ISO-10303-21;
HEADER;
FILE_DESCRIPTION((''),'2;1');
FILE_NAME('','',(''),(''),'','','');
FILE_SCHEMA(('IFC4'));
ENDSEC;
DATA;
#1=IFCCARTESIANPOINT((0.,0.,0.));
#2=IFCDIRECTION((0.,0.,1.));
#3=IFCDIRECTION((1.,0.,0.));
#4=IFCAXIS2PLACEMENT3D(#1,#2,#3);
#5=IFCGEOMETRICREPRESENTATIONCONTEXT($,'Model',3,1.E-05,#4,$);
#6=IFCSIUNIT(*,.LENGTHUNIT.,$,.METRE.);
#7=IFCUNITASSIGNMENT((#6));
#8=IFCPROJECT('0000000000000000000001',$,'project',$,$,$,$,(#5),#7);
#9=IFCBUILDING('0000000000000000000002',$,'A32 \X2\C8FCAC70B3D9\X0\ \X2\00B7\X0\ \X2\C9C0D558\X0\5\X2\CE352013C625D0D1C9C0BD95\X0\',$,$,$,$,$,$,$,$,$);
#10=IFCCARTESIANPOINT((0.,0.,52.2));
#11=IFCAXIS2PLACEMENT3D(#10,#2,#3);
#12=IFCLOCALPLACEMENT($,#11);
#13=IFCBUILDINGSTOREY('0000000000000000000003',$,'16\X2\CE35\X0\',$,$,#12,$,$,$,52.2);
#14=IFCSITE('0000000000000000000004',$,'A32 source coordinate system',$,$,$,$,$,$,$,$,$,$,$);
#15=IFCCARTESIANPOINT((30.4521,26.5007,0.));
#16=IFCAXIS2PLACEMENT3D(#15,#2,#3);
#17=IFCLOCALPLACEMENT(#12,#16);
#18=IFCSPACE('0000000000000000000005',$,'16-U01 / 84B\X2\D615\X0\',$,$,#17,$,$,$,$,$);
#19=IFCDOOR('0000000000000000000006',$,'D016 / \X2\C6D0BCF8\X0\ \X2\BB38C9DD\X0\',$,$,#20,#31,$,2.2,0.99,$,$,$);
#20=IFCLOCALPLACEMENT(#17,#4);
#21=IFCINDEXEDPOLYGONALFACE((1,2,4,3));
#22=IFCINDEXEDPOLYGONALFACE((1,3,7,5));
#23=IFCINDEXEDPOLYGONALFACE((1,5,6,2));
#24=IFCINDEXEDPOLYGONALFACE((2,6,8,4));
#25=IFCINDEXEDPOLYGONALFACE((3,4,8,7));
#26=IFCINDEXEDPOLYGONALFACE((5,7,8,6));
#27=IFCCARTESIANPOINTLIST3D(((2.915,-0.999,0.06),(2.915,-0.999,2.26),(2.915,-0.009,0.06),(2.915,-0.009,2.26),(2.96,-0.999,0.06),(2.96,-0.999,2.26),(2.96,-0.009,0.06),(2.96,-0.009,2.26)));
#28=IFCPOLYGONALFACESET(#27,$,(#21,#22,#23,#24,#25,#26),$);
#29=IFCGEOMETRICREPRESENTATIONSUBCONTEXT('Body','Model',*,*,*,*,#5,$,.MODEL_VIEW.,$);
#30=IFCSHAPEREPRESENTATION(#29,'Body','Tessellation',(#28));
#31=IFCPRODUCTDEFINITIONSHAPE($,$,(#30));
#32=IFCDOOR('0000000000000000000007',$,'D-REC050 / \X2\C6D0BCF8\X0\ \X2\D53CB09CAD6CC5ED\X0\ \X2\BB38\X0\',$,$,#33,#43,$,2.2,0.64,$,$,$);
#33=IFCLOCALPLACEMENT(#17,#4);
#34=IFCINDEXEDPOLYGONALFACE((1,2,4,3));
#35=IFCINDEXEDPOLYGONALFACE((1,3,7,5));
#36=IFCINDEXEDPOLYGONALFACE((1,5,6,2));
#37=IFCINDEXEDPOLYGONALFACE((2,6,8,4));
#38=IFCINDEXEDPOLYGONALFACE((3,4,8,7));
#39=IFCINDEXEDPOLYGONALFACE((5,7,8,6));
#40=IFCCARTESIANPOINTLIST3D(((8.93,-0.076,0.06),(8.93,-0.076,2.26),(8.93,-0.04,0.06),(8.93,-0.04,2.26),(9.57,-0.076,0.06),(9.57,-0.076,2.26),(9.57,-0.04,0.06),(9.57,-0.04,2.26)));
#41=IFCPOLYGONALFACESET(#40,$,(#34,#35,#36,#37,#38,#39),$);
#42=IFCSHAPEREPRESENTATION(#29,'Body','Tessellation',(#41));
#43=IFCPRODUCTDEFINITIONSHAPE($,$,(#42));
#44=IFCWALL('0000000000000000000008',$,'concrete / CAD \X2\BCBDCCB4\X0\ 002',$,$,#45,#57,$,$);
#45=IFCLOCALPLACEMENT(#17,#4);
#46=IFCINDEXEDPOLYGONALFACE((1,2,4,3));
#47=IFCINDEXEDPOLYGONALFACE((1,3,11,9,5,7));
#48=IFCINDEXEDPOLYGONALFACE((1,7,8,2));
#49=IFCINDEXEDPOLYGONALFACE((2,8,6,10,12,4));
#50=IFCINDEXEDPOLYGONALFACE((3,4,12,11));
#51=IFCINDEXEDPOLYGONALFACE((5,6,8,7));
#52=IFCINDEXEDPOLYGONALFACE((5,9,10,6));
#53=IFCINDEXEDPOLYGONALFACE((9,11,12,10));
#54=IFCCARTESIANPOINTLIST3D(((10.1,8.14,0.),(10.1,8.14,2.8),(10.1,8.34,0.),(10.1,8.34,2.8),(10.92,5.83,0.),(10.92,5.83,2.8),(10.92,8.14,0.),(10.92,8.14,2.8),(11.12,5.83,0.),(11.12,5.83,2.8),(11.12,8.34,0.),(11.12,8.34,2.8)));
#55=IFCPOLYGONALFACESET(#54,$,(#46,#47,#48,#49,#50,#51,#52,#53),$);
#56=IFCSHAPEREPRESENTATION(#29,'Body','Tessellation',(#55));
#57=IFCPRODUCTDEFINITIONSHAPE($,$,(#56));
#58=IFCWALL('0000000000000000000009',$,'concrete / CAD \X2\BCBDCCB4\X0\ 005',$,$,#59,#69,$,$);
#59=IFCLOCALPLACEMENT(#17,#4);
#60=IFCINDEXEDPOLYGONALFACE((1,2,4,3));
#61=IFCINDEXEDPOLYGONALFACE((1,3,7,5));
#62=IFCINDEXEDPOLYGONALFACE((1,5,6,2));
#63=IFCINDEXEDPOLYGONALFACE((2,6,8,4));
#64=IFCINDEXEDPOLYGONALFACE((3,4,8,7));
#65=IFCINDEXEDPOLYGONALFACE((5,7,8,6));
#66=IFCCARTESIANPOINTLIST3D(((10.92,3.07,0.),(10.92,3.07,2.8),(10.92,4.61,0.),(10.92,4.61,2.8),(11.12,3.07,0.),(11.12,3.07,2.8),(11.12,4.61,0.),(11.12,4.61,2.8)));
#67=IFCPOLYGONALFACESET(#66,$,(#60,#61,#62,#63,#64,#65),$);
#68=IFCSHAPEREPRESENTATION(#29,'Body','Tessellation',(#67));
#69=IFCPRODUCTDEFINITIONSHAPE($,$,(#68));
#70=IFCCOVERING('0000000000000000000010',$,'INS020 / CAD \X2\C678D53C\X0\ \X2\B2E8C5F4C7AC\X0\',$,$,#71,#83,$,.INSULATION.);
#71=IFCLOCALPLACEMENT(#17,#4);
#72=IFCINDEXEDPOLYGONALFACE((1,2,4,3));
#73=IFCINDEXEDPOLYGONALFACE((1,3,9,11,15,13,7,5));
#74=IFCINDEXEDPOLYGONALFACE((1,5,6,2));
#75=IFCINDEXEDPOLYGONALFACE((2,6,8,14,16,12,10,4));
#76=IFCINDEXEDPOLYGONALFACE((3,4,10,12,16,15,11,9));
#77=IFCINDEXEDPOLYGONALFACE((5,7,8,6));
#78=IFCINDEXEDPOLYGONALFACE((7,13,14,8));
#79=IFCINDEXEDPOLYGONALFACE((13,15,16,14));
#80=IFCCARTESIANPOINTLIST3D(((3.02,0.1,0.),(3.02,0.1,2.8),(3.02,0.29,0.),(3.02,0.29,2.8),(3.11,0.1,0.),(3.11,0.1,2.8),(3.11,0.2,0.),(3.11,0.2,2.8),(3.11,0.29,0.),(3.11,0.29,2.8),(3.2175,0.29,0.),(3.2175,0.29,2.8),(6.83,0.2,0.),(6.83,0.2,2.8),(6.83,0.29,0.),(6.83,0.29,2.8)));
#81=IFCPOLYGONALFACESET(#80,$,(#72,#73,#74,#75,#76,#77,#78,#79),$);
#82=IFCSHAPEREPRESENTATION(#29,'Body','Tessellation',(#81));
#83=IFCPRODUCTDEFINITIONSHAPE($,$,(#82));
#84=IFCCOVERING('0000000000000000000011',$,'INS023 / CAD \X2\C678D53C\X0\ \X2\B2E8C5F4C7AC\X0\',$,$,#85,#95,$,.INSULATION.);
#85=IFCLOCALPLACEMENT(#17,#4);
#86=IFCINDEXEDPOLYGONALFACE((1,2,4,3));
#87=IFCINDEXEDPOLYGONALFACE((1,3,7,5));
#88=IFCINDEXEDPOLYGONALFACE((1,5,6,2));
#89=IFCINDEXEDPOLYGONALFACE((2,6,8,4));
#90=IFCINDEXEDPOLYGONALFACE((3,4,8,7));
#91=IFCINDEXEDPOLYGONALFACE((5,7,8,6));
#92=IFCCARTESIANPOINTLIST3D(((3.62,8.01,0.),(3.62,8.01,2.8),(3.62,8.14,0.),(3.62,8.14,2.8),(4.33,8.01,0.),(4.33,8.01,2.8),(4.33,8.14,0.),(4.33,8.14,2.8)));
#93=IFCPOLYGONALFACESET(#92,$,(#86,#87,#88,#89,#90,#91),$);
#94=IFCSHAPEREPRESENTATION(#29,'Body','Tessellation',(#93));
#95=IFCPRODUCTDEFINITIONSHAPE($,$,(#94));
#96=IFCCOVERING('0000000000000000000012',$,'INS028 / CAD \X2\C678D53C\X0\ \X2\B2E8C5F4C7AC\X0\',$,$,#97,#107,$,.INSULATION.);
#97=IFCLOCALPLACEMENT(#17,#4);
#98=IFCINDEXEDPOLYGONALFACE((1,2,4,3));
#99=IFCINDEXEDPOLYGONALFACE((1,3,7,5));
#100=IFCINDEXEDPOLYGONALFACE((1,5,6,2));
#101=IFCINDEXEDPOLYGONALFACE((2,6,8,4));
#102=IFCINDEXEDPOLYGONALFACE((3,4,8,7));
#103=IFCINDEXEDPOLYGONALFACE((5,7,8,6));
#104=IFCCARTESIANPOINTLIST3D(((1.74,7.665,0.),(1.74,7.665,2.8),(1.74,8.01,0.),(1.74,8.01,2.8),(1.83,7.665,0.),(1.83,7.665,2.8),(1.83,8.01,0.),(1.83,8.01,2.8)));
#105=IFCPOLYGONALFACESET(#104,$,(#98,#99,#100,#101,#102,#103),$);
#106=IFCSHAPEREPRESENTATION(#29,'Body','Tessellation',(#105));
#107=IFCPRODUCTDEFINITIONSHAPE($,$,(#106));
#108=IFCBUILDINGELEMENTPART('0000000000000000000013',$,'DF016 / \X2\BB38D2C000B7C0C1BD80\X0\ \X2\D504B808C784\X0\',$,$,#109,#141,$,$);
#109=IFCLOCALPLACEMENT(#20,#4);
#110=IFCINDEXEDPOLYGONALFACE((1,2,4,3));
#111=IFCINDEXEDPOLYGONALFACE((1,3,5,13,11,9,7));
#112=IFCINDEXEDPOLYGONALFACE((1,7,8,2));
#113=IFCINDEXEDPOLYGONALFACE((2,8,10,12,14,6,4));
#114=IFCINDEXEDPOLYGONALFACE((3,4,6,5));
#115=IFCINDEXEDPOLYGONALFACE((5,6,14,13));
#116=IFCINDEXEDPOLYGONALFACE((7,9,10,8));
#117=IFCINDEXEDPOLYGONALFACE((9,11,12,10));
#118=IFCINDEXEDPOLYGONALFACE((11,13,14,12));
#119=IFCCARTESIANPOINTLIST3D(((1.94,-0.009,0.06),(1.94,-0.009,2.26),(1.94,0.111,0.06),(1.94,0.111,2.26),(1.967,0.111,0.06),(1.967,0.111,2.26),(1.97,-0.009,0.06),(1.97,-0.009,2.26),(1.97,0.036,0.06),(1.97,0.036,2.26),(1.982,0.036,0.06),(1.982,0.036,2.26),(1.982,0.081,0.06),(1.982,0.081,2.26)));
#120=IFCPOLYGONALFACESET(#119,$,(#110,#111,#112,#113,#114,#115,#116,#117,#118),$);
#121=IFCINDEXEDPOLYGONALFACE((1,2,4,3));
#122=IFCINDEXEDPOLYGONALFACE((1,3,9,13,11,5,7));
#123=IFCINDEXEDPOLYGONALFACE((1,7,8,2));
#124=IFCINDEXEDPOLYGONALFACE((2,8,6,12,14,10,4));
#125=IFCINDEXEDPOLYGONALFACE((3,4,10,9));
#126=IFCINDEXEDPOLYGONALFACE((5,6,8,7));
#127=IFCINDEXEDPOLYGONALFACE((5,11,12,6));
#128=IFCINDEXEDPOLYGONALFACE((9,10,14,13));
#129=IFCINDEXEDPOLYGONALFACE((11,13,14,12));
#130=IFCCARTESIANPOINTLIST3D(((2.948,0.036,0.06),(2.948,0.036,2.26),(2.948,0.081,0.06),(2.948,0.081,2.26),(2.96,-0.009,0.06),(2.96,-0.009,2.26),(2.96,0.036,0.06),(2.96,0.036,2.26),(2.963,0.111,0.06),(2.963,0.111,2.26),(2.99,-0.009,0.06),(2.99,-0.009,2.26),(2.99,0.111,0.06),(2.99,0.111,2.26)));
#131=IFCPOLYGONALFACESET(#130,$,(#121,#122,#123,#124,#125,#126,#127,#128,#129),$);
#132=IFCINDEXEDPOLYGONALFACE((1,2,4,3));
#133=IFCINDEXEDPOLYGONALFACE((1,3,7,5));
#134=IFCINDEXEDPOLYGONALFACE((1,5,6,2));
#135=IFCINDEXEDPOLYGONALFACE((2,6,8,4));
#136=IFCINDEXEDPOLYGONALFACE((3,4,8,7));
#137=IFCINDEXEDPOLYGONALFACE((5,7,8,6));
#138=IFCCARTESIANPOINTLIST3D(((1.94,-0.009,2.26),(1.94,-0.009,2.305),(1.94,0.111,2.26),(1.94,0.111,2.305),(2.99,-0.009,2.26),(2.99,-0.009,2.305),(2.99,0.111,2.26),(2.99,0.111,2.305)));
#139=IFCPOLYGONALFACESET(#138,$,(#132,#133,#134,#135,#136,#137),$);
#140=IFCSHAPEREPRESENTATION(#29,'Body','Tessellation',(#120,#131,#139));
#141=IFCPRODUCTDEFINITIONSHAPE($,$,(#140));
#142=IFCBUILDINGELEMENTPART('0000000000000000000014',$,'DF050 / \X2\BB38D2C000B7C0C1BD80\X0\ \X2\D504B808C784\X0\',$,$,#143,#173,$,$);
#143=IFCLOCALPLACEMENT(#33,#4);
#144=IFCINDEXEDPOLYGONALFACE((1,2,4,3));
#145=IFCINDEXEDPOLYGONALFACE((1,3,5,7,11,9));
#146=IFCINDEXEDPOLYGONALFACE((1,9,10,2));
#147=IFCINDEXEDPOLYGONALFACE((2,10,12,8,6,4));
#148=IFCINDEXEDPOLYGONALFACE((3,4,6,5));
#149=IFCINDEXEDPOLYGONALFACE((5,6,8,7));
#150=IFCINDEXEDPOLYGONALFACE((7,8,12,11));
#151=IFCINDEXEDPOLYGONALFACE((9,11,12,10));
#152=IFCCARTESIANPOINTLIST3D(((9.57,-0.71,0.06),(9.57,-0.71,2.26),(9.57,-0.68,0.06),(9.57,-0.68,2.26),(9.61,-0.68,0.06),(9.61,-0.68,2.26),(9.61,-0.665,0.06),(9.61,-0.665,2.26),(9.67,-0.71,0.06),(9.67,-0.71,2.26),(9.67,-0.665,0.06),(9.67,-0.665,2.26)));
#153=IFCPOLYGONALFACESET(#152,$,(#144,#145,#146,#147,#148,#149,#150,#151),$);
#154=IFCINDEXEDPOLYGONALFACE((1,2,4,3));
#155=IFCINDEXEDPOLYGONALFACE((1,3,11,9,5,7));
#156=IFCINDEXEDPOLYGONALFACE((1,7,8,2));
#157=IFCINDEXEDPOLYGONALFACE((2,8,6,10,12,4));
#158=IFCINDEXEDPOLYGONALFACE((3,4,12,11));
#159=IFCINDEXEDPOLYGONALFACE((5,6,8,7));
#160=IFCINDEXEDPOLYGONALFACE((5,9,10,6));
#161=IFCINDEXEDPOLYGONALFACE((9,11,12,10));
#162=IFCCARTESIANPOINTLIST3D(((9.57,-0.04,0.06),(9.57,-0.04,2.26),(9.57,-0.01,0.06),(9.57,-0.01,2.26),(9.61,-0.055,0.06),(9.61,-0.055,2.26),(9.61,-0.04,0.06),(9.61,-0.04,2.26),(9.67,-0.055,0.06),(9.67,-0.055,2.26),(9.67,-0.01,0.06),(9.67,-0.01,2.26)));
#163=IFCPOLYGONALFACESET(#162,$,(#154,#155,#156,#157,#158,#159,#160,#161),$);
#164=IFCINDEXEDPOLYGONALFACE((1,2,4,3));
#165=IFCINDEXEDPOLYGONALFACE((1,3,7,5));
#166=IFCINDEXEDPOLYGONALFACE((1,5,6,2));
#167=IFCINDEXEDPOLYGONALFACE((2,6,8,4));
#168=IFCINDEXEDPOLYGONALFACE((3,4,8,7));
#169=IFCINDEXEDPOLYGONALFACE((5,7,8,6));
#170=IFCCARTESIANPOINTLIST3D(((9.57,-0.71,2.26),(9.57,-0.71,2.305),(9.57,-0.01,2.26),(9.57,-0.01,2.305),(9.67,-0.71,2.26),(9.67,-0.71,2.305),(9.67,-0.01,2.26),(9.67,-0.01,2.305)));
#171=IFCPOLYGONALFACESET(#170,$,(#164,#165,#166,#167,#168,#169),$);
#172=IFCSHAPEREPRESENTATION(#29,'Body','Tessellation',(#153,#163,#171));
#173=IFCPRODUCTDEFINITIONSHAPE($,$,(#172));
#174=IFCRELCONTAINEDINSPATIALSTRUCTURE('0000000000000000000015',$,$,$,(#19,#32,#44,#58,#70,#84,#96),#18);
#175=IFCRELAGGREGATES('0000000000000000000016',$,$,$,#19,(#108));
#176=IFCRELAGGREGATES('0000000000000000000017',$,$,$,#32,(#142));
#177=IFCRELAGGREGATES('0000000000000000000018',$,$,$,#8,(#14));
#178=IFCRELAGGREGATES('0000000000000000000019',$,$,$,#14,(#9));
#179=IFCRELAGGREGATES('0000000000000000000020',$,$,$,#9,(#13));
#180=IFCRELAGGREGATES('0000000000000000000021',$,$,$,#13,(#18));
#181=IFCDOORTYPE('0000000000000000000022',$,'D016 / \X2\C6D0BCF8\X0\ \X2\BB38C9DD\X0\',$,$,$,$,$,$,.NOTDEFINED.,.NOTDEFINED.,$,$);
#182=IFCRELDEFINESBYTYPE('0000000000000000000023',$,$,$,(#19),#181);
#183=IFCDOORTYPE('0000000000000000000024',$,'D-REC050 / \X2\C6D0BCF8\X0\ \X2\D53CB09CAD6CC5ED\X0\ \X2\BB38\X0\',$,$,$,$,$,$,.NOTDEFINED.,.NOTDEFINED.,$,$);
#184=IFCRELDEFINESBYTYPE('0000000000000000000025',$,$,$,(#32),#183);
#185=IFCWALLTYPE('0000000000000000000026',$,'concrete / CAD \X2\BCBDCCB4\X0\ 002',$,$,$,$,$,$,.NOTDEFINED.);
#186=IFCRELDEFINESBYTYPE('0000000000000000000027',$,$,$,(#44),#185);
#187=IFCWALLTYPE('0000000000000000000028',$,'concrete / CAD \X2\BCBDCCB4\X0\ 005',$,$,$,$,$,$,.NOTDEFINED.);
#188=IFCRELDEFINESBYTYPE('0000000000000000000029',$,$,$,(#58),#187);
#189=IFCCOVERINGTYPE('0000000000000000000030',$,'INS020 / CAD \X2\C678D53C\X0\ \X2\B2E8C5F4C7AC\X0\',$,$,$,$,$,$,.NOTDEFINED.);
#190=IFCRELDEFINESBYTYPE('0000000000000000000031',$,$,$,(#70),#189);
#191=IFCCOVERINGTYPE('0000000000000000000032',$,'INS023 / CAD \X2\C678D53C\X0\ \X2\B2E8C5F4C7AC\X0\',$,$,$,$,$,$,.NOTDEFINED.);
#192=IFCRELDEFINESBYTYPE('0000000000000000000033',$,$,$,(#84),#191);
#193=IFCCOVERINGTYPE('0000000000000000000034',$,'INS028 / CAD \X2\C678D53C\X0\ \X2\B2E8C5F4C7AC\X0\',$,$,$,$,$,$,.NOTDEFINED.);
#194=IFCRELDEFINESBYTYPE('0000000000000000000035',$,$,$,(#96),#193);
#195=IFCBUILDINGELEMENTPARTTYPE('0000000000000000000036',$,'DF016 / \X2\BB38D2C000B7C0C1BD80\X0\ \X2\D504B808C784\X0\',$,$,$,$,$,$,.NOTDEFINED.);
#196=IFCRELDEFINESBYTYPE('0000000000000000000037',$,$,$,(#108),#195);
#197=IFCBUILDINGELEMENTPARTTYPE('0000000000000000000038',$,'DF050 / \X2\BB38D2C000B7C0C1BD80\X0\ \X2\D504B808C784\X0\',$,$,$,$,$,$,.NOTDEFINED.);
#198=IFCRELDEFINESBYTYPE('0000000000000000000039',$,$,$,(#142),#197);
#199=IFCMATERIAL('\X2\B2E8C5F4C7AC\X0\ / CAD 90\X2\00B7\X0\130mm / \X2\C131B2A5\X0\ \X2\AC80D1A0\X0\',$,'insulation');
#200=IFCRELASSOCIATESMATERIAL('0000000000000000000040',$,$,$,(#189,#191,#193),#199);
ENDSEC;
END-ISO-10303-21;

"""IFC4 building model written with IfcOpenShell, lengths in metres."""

from ifc_helpers import new_model, si_unit, frame, origin, origin_with_axes, place, context, subcontext, project, spatial, polyline, outline, extrude, source, transform, mapped, material, type_object, type_shapes, element, aggregate, save


model = new_model("IFC4")

# Units and contexts
model_context = context("Model", 3, precision=1e-05, world=origin_with_axes())
body_context = subcontext(model_context, "Body", "Model", "MODEL_VIEW")
ifc_project = project(units=[si_unit("LENGTHUNIT", "METRE")], contexts=[model_context])

# Site, building, storey, space
storey_placement = place(None, frame((0.0, 0.0, 52.2), z_axis=(0.0, 0.0, 1.0), x_axis=(1.0, 0.0, 0.0)))
space_placement = place(storey_placement, frame((30.4521, 26.5007, 0.0), z_axis=(0.0, 0.0, 1.0), x_axis=(1.0, 0.0, 0.0)))
site = spatial("IfcSite", under=ifc_project, Name="A32 source coordinate system")
building = spatial("IfcBuilding", under=site, Name="A32 주거동 · 지하5층–옥탑지붕")
storey = spatial("IfcBuildingStorey", under=building, at=storey_placement, Name="16층", Elevation=52.2)
space = spatial("IfcSpace", under=storey, at=space_placement, Name="16-U01 / 84B형")

# Doors
door_type_1 = type_object("IfcDoorType", Name="D016 / 원본 문짝", OperationType="NOTDEFINED", PredefinedType="NOTDEFINED")
shared_shape_1 = source(origin(), body_context, "Body", "SweptSolid", [
    extrude(outline(polyline([(2.96, -0.009), (2.96, -0.999), (2.915, -0.999), (2.915, -0.009), (2.96, -0.009)])), frame((0.0, 0.0, 0.06)), (0.0, 0.0, 1.0), 2.2),
])
type_shapes(door_type_1, [shared_shape_1])
door_1_placement = place(space_placement, origin_with_axes())
door_1 = element("IfcDoor", 1, at=door_1_placement, inside=space, type_object=door_type_1, Name="D016 / 원본 문짝", OverallHeight=2.2, OverallWidth=0.99, context=body_context, shape_type="MappedRepresentation", body=[
    mapped(shared_shape_1, transform((0.0, 0.0, 0.0), scale=1.0)),
])
door_type_2 = type_object("IfcDoorType", Name="D-REC050 / 원본 피난구역 문", OperationType="NOTDEFINED", PredefinedType="NOTDEFINED")
shared_shape_2 = source(origin(), body_context, "Body", "SweptSolid", [
    extrude(outline(polyline([(9.57, -0.04), (9.57, -0.076), (8.93, -0.076), (8.93, -0.04), (9.57, -0.04)])), frame((0.0, 0.0, 0.06)), (0.0, 0.0, 1.0), 2.2),
])
type_shapes(door_type_2, [shared_shape_2])
door_2_placement = place(space_placement, origin_with_axes())
door_2 = element("IfcDoor", 2, at=door_2_placement, inside=space, type_object=door_type_2, Name="D-REC050 / 원본 피난구역 문", OverallHeight=2.2, OverallWidth=0.64, context=body_context, shape_type="MappedRepresentation", body=[
    mapped(shared_shape_2, transform((0.0, 0.0, 0.0), scale=1.0)),
])

# Walls
wall_type_1 = type_object("IfcWallType", Name="concrete / CAD 벽체 002", PredefinedType="NOTDEFINED")
shared_shape_3 = source(origin(), body_context, "Body", "SweptSolid", [
    extrude(outline(polyline([(11.12, 5.83), (10.92, 5.83), (10.92, 8.14), (10.1, 8.14), (10.1, 8.34), (11.12, 8.34), (11.12, 5.83)])), origin(), (0.0, 0.0, 1.0), 2.8),
])
type_shapes(wall_type_1, [shared_shape_3])
wall_1_placement = place(space_placement, origin_with_axes())
element("IfcWall", 3, at=wall_1_placement, inside=space, type_object=wall_type_1, Name="concrete / CAD 벽체 002", context=body_context, shape_type="MappedRepresentation", body=[
    mapped(shared_shape_3, transform((0.0, 0.0, 0.0), scale=1.0)),
])
wall_type_2 = type_object("IfcWallType", Name="concrete / CAD 벽체 005", PredefinedType="NOTDEFINED")
shared_shape_4 = source(origin(), body_context, "Body", "SweptSolid", [
    extrude(outline(polyline([(11.12, 3.07), (10.92, 3.07), (10.92, 4.61), (11.12, 4.61), (11.12, 3.07)])), origin(), (0.0, 0.0, 1.0), 2.8),
])
type_shapes(wall_type_2, [shared_shape_4])
wall_2_placement = place(space_placement, origin_with_axes())
element("IfcWall", 4, at=wall_2_placement, inside=space, type_object=wall_type_2, Name="concrete / CAD 벽체 005", context=body_context, shape_type="MappedRepresentation", body=[
    mapped(shared_shape_4, transform((0.0, 0.0, 0.0), scale=1.0)),
])

# Coverings
ifc_material = material(Name="단열재 / CAD 90·130mm / 성능 검토", Category="insulation")
covering_type_1 = type_object("IfcCoveringType", Name="INS020 / CAD 외피 단열재", PredefinedType="NOTDEFINED", material=ifc_material)
shared_shape_5 = source(origin(), body_context, "Body", "SweptSolid", [
    extrude(outline(polyline([(3.11, 0.2), (3.11, 0.1), (3.02, 0.1), (3.02, 0.29), (3.11, 0.29), (3.2175, 0.29), (6.83, 0.29), (6.83, 0.2), (3.11, 0.2)])), origin(), (0.0, 0.0, 1.0), 2.8),
])
type_shapes(covering_type_1, [shared_shape_5])
covering_1_placement = place(space_placement, origin_with_axes())
element("IfcCovering", 5, at=covering_1_placement, inside=space, type_object=covering_type_1, Name="INS020 / CAD 외피 단열재", PredefinedType="INSULATION", context=body_context, shape_type="MappedRepresentation", body=[
    mapped(shared_shape_5, transform((0.0, 0.0, 0.0), scale=1.0)),
])
covering_type_2 = type_object("IfcCoveringType", Name="INS023 / CAD 외피 단열재", PredefinedType="NOTDEFINED", material=ifc_material)
shared_shape_6 = source(origin(), body_context, "Body", "SweptSolid", [
    extrude(outline(polyline([(4.33, 8.01), (3.62, 8.01), (3.62, 8.14), (4.33, 8.14), (4.33, 8.01)])), origin(), (0.0, 0.0, 1.0), 2.8),
])
type_shapes(covering_type_2, [shared_shape_6])
covering_2_placement = place(space_placement, origin_with_axes())
element("IfcCovering", 6, at=covering_2_placement, inside=space, type_object=covering_type_2, Name="INS023 / CAD 외피 단열재", PredefinedType="INSULATION", context=body_context, shape_type="MappedRepresentation", body=[
    mapped(shared_shape_6, transform((0.0, 0.0, 0.0), scale=1.0)),
])
covering_type_3 = type_object("IfcCoveringType", Name="INS028 / CAD 외피 단열재", PredefinedType="NOTDEFINED", material=ifc_material)
shared_shape_7 = source(origin(), body_context, "Body", "SweptSolid", [
    extrude(outline(polyline([(1.74, 8.01), (1.83, 8.01), (1.83, 7.665), (1.74, 7.665), (1.74, 8.01)])), origin(), (0.0, 0.0, 1.0), 2.8),
])
type_shapes(covering_type_3, [shared_shape_7])
covering_3_placement = place(space_placement, origin_with_axes())
element("IfcCovering", 7, at=covering_3_placement, inside=space, type_object=covering_type_3, Name="INS028 / CAD 외피 단열재", PredefinedType="INSULATION", context=body_context, shape_type="MappedRepresentation", body=[
    mapped(shared_shape_7, transform((0.0, 0.0, 0.0), scale=1.0)),
])

# Building element parts
building_element_part_type_1 = type_object("IfcBuildingElementPartType", Name="DF016 / 문틀·상부 프레임", PredefinedType="NOTDEFINED")
shared_shape_8 = source(origin(), body_context, "Body", "SweptSolid", [
    extrude(outline(polyline([(1.94, 0.111), (1.967, 0.111), (1.982, 0.081), (1.982, 0.036), (1.97, 0.036), (1.97, -0.009), (1.94, -0.009), (1.94, 0.111)])), frame((0.0, 0.0, 0.06)), (0.0, 0.0, 1.0), 2.2),
    extrude(outline(polyline([(2.96, -0.009), (2.96, 0.036), (2.948, 0.036), (2.948, 0.081), (2.963, 0.111), (2.99, 0.111), (2.99, -0.009), (2.96, -0.009)])), frame((0.0, 0.0, 0.06)), (0.0, 0.0, 1.0), 2.2),
    extrude(outline(polyline([(1.94, -0.009), (1.94, 0.111), (2.99, 0.111), (2.99, -0.009), (1.94, -0.009)])), frame((0.0, 0.0, 2.26)), (0.0, 0.0, 1.0), 0.045),
])
type_shapes(building_element_part_type_1, [shared_shape_8])
building_element_part_1_placement = place(door_1_placement, origin_with_axes())
building_element_part_1 = element("IfcBuildingElementPart", 8, at=building_element_part_1_placement, type_object=building_element_part_type_1, Name="DF016 / 문틀·상부 프레임", context=body_context, shape_type="MappedRepresentation", body=[
    mapped(shared_shape_8, transform((0.0, 0.0, 0.0), scale=1.0)),
])
aggregate(door_1, [building_element_part_1])
building_element_part_type_2 = type_object("IfcBuildingElementPartType", Name="DF050 / 문틀·상부 프레임", PredefinedType="NOTDEFINED")
shared_shape_9 = source(origin(), body_context, "Body", "SweptSolid", [
    extrude(outline(polyline([(9.57, -0.68), (9.61, -0.68), (9.61, -0.665), (9.67, -0.665), (9.67, -0.71), (9.57, -0.71), (9.57, -0.68)])), frame((0.0, 0.0, 0.06)), (0.0, 0.0, 1.0), 2.2),
    extrude(outline(polyline([(9.67, -0.01), (9.67, -0.055), (9.61, -0.055), (9.61, -0.04), (9.57, -0.04), (9.57, -0.01), (9.67, -0.01)])), frame((0.0, 0.0, 0.06)), (0.0, 0.0, 1.0), 2.2),
    extrude(outline(polyline([(9.57, -0.71), (9.57, -0.01), (9.67, -0.01), (9.67, -0.71), (9.57, -0.71)])), frame((0.0, 0.0, 2.26)), (0.0, 0.0, 1.0), 0.045),
])
type_shapes(building_element_part_type_2, [shared_shape_9])
building_element_part_2_placement = place(door_2_placement, origin_with_axes())
building_element_part_2 = element("IfcBuildingElementPart", 9, at=building_element_part_2_placement, type_object=building_element_part_type_2, Name="DF050 / 문틀·상부 프레임", context=body_context, shape_type="MappedRepresentation", body=[
    mapped(shared_shape_9, transform((0.0, 0.0, 0.0), scale=1.0)),
])
aggregate(door_2, [building_element_part_2])

save(model, "model.ifc")
